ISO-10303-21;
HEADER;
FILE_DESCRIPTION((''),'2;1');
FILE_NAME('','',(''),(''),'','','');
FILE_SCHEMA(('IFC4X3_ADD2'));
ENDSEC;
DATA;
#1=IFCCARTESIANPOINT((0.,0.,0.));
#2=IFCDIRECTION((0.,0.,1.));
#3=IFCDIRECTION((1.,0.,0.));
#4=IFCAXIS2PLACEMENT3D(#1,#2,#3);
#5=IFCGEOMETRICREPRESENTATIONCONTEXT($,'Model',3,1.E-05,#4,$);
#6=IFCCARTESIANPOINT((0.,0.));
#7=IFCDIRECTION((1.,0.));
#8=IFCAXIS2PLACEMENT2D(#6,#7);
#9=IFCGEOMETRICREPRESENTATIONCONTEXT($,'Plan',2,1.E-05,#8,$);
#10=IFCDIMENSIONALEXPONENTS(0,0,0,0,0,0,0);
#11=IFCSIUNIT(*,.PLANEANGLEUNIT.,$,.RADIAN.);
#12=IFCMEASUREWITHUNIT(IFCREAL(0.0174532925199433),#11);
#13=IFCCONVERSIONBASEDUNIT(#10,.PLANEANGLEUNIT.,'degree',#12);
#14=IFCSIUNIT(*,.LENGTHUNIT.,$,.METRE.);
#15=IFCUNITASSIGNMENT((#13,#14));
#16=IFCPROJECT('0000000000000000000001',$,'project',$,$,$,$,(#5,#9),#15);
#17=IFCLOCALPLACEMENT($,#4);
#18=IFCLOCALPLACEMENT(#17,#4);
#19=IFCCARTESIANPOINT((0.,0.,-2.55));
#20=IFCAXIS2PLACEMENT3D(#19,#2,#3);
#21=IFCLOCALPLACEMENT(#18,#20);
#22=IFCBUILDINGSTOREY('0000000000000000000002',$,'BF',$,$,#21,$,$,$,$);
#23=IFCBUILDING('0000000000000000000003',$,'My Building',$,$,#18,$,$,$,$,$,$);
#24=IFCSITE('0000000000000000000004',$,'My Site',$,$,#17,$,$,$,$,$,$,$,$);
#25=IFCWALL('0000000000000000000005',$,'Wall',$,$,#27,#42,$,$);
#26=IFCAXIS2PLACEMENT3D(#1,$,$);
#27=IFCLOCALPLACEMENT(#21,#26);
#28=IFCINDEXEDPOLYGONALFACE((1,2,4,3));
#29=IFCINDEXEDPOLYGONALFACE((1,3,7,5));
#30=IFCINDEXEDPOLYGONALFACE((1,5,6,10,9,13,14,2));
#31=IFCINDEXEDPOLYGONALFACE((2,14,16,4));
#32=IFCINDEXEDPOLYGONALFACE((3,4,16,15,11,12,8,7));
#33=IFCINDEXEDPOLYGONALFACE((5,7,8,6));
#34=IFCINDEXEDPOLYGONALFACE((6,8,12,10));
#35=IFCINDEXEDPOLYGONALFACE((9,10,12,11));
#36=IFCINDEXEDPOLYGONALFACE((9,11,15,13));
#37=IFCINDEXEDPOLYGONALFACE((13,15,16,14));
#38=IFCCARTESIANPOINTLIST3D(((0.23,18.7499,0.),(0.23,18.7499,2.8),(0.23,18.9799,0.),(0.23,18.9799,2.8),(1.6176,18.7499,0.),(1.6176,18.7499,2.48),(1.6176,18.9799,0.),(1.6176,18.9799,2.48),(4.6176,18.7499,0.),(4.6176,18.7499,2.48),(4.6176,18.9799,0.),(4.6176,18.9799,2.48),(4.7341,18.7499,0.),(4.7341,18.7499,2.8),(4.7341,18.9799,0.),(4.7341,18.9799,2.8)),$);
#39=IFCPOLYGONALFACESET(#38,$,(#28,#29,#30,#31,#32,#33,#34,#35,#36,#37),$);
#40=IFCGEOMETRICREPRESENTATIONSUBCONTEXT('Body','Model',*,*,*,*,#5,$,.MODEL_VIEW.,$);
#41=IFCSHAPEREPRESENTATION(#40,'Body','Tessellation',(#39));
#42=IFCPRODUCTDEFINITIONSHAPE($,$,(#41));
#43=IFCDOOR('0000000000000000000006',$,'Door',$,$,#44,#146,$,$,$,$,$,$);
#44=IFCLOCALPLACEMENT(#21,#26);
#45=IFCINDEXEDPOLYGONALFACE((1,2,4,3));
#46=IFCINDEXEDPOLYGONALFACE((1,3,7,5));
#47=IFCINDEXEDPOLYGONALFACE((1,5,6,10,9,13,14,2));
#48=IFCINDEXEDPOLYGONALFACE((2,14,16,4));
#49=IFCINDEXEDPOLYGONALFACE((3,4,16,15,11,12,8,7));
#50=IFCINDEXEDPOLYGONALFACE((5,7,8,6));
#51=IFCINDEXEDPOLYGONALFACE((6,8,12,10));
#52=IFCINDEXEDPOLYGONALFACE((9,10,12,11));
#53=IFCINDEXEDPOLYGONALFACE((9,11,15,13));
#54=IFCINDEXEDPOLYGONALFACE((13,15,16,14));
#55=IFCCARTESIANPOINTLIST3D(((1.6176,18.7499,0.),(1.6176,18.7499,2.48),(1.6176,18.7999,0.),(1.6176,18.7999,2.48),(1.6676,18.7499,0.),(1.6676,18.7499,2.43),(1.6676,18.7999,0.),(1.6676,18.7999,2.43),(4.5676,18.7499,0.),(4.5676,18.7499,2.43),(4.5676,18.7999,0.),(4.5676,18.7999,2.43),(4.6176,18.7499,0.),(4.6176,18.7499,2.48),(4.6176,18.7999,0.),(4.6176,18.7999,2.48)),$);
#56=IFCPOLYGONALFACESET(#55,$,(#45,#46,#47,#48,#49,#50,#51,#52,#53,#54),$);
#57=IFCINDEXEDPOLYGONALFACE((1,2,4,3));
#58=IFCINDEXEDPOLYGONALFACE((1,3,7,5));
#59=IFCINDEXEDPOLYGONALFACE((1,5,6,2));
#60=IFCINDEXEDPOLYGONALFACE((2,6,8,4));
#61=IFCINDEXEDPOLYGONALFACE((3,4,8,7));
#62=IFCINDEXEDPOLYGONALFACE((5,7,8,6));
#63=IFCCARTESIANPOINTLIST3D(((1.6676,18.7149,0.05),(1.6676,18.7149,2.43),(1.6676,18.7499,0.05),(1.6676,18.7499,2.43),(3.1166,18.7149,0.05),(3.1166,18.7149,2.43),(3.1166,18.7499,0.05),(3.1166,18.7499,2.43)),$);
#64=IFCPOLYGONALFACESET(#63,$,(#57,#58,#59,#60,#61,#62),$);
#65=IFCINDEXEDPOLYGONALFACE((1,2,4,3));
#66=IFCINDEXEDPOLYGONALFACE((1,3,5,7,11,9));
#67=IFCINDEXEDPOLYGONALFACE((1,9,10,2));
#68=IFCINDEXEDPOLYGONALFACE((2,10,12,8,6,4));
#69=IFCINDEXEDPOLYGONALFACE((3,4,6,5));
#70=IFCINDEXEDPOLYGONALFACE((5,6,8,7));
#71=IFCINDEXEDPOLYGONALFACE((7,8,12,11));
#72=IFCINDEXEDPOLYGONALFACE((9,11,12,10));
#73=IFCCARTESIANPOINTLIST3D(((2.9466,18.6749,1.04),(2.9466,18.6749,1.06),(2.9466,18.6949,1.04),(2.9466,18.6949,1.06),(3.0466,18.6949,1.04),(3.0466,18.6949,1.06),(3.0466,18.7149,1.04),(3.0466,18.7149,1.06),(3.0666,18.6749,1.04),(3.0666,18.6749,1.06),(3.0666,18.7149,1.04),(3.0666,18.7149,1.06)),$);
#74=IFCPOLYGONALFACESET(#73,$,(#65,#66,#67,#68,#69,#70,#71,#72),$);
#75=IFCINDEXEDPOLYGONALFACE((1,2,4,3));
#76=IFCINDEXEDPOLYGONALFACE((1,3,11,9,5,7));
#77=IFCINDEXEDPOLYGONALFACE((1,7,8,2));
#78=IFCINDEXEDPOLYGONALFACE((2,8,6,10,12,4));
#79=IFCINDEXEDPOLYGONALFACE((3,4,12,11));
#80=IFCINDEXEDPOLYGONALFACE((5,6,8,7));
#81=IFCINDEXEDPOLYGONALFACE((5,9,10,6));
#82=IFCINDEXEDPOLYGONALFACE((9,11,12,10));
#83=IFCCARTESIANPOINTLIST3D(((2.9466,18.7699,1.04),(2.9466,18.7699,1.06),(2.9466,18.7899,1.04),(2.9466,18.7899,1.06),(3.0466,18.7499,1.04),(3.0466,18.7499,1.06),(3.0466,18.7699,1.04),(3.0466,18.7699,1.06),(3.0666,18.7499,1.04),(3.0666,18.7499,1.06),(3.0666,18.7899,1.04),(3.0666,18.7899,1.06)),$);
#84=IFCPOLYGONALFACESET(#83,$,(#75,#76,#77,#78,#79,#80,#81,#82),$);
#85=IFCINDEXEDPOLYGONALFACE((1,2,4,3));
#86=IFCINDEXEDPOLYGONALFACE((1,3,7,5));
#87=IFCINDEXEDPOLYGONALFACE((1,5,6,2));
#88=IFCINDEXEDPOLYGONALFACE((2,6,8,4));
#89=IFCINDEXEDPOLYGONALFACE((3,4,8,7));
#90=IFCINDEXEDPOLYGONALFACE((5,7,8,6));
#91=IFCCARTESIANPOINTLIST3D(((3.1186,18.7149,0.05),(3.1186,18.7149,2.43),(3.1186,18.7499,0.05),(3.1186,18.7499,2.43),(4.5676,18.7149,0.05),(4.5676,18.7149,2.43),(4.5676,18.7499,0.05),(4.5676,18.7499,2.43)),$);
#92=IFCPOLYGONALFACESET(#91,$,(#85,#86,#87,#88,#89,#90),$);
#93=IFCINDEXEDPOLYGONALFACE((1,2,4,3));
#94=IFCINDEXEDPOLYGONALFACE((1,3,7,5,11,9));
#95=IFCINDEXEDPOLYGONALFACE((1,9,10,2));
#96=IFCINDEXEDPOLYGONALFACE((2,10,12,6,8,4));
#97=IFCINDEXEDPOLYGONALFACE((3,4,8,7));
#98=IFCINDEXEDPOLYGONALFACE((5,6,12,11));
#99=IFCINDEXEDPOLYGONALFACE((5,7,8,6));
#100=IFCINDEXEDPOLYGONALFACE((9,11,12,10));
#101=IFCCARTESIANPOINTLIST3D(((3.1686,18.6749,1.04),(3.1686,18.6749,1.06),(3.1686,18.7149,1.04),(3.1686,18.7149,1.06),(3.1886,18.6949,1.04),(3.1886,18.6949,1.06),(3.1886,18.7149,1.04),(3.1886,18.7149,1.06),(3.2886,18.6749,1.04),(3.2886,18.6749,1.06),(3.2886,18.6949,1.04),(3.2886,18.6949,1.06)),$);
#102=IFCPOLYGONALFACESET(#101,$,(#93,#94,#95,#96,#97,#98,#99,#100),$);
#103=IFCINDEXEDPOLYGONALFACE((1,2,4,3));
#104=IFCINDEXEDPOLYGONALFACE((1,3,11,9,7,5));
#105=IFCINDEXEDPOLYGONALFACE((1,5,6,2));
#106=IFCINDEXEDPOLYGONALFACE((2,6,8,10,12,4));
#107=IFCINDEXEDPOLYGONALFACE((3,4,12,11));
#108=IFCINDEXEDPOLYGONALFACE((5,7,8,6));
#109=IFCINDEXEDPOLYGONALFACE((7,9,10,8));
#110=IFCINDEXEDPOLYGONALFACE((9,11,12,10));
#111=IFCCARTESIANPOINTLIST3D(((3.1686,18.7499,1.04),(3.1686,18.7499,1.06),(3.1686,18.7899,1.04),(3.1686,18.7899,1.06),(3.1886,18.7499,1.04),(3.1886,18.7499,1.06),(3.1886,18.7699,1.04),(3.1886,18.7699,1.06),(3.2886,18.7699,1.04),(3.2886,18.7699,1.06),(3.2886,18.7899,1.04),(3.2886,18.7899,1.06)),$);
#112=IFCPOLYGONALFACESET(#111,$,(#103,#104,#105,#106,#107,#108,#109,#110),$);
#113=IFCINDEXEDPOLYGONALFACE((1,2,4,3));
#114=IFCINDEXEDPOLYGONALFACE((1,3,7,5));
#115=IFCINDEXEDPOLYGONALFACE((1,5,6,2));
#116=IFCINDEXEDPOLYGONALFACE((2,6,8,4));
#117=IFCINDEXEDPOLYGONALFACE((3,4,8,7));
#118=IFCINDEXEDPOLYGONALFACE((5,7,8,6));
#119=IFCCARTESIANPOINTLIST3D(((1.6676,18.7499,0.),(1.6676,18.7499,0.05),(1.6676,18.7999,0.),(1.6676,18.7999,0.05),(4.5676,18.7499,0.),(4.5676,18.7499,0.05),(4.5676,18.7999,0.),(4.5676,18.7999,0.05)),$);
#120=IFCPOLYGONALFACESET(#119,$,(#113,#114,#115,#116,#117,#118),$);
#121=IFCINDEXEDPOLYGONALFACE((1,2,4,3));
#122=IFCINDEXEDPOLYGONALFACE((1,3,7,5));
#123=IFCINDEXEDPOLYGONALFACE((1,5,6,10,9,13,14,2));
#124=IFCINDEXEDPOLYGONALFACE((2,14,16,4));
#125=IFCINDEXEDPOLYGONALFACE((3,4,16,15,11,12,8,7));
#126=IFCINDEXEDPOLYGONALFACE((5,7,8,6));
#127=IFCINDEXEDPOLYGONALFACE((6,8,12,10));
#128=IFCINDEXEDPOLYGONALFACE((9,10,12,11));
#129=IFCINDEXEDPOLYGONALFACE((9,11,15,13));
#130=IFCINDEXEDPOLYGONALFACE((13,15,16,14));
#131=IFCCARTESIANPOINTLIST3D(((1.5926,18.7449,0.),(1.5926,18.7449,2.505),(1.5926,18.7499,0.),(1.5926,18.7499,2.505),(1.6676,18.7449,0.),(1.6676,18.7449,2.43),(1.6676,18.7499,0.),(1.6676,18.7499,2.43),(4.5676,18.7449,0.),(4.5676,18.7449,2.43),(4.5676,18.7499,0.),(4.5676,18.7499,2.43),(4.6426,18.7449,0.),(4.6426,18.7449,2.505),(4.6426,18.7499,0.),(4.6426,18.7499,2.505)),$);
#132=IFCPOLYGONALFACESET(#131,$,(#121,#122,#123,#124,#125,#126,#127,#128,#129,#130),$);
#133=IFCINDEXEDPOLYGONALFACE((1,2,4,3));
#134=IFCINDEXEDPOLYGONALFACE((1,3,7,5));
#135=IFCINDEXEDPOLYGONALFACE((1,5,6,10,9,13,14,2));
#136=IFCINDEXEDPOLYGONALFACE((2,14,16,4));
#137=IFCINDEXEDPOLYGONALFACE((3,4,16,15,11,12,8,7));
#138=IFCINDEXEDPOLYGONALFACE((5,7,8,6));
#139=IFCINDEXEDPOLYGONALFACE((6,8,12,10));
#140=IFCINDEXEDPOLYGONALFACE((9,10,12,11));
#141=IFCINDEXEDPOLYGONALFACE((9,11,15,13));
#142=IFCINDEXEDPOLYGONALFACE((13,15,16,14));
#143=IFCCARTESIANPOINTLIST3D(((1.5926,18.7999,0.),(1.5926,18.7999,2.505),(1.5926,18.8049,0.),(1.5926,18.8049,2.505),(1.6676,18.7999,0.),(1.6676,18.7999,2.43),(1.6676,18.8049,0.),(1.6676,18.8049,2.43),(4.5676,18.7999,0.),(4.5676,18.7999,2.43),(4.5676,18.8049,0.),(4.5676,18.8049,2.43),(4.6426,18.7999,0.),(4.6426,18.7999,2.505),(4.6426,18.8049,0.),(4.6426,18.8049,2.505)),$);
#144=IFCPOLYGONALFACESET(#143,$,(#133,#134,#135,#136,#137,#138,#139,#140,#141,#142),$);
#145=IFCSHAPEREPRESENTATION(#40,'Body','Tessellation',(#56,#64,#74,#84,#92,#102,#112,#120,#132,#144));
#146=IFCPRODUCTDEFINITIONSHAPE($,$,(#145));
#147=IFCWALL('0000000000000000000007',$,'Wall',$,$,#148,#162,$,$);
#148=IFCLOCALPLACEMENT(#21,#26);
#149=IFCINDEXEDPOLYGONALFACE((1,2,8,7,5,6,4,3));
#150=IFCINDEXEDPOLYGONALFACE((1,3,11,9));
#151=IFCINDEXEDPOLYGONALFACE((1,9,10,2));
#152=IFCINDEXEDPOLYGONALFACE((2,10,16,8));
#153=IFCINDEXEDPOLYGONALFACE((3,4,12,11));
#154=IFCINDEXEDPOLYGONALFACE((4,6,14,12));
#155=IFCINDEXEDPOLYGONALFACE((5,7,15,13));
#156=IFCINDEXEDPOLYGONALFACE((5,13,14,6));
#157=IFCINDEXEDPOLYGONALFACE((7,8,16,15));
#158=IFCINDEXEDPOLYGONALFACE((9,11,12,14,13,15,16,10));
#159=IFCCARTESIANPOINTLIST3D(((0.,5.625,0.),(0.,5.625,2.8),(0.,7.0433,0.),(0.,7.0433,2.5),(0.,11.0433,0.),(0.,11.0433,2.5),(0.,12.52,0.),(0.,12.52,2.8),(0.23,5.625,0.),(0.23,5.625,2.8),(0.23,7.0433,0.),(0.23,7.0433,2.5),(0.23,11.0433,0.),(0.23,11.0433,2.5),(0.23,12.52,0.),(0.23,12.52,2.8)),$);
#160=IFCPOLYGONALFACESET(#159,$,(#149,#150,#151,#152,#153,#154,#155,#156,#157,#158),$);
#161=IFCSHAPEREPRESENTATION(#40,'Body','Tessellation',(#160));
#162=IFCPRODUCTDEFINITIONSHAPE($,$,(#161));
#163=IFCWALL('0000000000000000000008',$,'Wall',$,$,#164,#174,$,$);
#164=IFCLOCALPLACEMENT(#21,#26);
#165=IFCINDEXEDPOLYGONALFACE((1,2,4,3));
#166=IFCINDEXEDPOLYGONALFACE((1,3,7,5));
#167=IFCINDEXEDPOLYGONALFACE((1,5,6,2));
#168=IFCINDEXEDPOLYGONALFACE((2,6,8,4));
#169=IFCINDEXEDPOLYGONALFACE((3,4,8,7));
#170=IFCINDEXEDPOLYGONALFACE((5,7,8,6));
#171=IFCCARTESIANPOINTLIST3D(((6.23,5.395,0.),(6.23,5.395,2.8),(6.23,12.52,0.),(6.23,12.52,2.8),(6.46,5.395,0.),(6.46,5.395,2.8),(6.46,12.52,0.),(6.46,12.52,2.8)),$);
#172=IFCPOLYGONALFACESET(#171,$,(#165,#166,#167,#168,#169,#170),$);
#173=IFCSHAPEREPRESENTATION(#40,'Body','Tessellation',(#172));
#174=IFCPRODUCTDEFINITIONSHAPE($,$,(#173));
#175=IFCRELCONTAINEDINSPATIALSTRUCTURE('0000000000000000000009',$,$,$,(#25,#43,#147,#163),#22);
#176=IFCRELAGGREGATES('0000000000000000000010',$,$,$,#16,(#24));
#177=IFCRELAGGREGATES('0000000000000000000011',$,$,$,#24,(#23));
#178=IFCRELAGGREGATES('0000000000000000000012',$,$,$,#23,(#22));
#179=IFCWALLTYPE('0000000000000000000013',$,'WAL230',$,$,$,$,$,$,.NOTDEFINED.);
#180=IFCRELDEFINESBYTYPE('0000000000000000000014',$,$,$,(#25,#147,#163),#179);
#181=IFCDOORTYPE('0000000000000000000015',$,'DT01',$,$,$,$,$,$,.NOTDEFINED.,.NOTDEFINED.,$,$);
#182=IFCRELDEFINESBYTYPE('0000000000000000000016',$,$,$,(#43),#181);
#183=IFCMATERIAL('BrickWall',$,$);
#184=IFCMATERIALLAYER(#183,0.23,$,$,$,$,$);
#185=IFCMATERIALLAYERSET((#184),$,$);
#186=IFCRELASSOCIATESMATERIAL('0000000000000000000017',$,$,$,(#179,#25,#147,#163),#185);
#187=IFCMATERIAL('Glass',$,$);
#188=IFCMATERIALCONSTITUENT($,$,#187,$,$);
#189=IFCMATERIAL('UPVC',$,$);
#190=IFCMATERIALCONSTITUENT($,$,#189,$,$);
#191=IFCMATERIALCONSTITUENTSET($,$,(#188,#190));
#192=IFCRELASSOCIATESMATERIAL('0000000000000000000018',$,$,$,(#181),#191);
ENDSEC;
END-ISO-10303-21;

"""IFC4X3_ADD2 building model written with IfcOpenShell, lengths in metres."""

from ifc_helpers import new_model, entity, si_unit, converted_unit, frame, origin_with_axes, origin_2d_with_axis, place, context, subcontext, project, spatial, line, indexed_curve, outline, extrude, shape, source, transform, mapped, material, layer, layer_set, layer_usage, constituent, constituent_set, type_object, type_shapes, element, fill, save


model = new_model("IFC4X3_ADD2")

# Units and contexts
model_context = context("Model", 3, precision=1e-05, world=origin_with_axes())
plan_context = context("Plan", 2, precision=1e-05, world=origin_2d_with_axis())
body_context_1 = subcontext(model_context, "Body", "Model", "MODEL_VIEW")
body_context_2 = subcontext(plan_context, "Body", "Plan", "PLAN_VIEW")
ifc_project = project(units=[converted_unit("PLANEANGLEUNIT", "degree", entity("IfcReal", 0.0174532925199433), si_unit("PLANEANGLEUNIT", "RADIAN"), dimensions=[0, 0, 0, 0, 0, 0, 0]), si_unit("LENGTHUNIT", "METRE")], contexts=[model_context, plan_context])

# Site, building, storey
site_placement = place(None, origin_with_axes())
site = spatial("IfcSite", under=ifc_project, at=site_placement, Name="My Site")
building_placement = place(site_placement, origin_with_axes())
building = spatial("IfcBuilding", under=site, at=building_placement, Name="My Building")
storey_placement = place(building_placement, frame((0.0, 0.0, -2.55), z_axis=(0.0, 0.0, 1.0), x_axis=(1.0, 0.0, 0.0)))
storey = spatial("IfcBuildingStorey", under=building, at=storey_placement, Name="BF")

# Shared definitions
ifc_material_1 = material(Name="BrickWall")

# Wall, opening, door
ifc_layer_1 = layer(ifc_material_1, 0.23)
ifc_layer_set_1 = layer_set([ifc_layer_1])
ifc_layer_usage_1 = layer_usage(ifc_layer_set_1, "AXIS2", "POSITIVE", 0.0)
wall_type = type_object("IfcWallType", Name="WAL230", PredefinedType="NOTDEFINED", material=ifc_layer_set_1)
wall_1_placement = place(storey_placement, frame((0.23, 18.7499, 0.0), z_axis=(0.0, 0.0, 1.0), x_axis=(1.0, 0.0, 0.0)))
wall_1 = element("IfcWall", 1, at=wall_1_placement, inside=storey, type_object=wall_type, material=ifc_layer_usage_1, Name="Wall", context=body_context_1, shape_type="SweptSolid", body=[
    extrude(outline(indexed_curve([(0.0, 0.0), (0.0, 0.23), (4.5041, 0.23), (4.5041, 0.0), (0.0, 0.0)], self_intersect=False)), origin_with_axes(), (0.0, 0.0, 1.0), 2.8),
])
shared_shape_1 = source(origin_with_axes(), body_context_1, "Body", "SweptSolid", [
    extrude(outline(indexed_curve([(0.0, 0.0), (3.0, 0.0), (3.0, 2.48), (0.0, 2.48)], segments=[line(1, 2, 3, 4, 1)])), frame((0.0, -0.6, 0.0), z_axis=(0.0, -1.0, 0.0), x_axis=(1.0, 0.0, 0.0)), (0.0, 0.0, -1.0), 1.2),
])
opening_1_placement = place(wall_1_placement, frame((1.3876, 0.0, 0.0), z_axis=(0.0, 0.0, 1.0), x_axis=(1.0, 0.0, 0.0)))
opening_1 = element("IfcOpeningElement", 2, at=opening_1_placement, cuts=wall_1, PredefinedType="OPENING", context=body_context_1, shape_type="MappedRepresentation", body=[
    mapped(shared_shape_1, transform((0.0, 0.0, 0.0), x_axis=(1.0, 0.0, 0.0), y_axis=(0.0, 1.0, 0.0), z_axis=(0.0, 0.0, 1.0), scale=1.0)),
])
ifc_material_2 = material(Name="Glass")
ifc_constituent_1 = constituent(ifc_material_2)
ifc_material_3 = material(Name="UPVC")
ifc_constituent_2 = constituent(ifc_material_3)
ifc_constituent_set = constituent_set(constituents=[ifc_constituent_1, ifc_constituent_2])
door_type = type_object("IfcDoorType", Name="DT01", OperationType="NOTDEFINED", PredefinedType="NOTDEFINED", material=ifc_constituent_set)
shared_shape_2 = source(origin_with_axes(), body_context_1, "Body", "SweptSolid", [
    extrude(outline(indexed_curve([(3.0, 0.0), (3.0, 2.48), (0.0, 2.48), (0.0, 0.0), (0.05, 0.0), (0.05, 2.43), (2.95, 2.43), (2.95, 0.0)], segments=[line(5, 4), line(4, 3), line(3, 2), line(2, 1), line(1, 8), line(8, 7), line(7, 6), line(6, 5)], self_intersect=False)), frame((0.0, 0.0, 0.0), z_axis=(0.0, -1.0, 0.0), x_axis=(1.0, 0.0, 0.0)), (0.0, 0.0, -1.0), 0.05),
    extrude(outline(indexed_curve([(0.0, 0.0), (1.449, 0.0), (1.449, 0.035), (0.0, 0.035)], segments=[line(1, 2, 3, 4, 1)])), frame((0.05, -0.035, 0.05), z_axis=(0.0, 0.0, 1.0), x_axis=(1.0, 0.0, 0.0)), (0.0, 0.0, 1.0), 2.38),
    extrude(outline(indexed_curve([(0.0, 0.0), (0.0, -0.04), (-0.12, -0.04), (-0.12, -0.02), (-0.02, -0.02), (-0.02, 0.0)], segments=[line(1, 2, 3, 4, 5, 6, 1)])), frame((1.449, -0.035, 1.04), z_axis=(0.0, 0.0, 1.0), x_axis=(1.0, 0.0, 0.0)), (0.0, 0.0, 1.0), 0.02),
    extrude(outline(indexed_curve([(0.0, 0.0), (0.0, 0.04), (-0.12, 0.04), (-0.12, 0.02), (-0.02, 0.02), (-0.02, 0.0)], segments=[line(1, 2, 3, 4, 5, 6, 1)])), frame((1.449, 0.0, 1.04), z_axis=(0.0, 0.0, 1.0), x_axis=(1.0, 0.0, 0.0)), (0.0, 0.0, 1.0), 0.02),
    extrude(outline(indexed_curve([(0.0, 0.0), (-1.449, 0.0), (-1.449, 0.035), (0.0, 0.035)], segments=[line(1, 2, 3, 4, 1)])), frame((2.95, -0.035, 0.05), z_axis=(0.0, 0.0, 1.0), x_axis=(1.0, 0.0, 0.0)), (0.0, 0.0, 1.0), 2.38),
    extrude(outline(indexed_curve([(0.0, 0.0), (0.0, -0.04), (0.12, -0.04), (0.12, -0.02), (0.02, -0.02), (0.02, 0.0)], segments=[line(1, 2, 3, 4, 5, 6, 1)])), frame((1.551, -0.035, 1.04), z_axis=(0.0, 0.0, 1.0), x_axis=(1.0, 0.0, 0.0)), (0.0, 0.0, 1.0), 0.02),
    extrude(outline(indexed_curve([(0.0, 0.0), (0.0, 0.04), (0.12, 0.04), (0.12, 0.02), (0.02, 0.02), (0.02, 0.0)], segments=[line(1, 2, 3, 4, 5, 6, 1)])), frame((1.551, 0.0, 1.04), z_axis=(0.0, 0.0, 1.0), x_axis=(1.0, 0.0, 0.0)), (0.0, 0.0, 1.0), 0.02),
    extrude(outline(indexed_curve([(0.0, 0.0), (2.9, 0.0), (2.9, 0.05), (0.0, 0.05)], segments=[line(1, 2, 3, 4, 1)])), frame((0.05, 0.0, 0.0), z_axis=(0.0, 0.0, 1.0), x_axis=(1.0, 0.0, 0.0)), (0.0, 0.0, 1.0), 0.05),
    extrude(outline(indexed_curve([(0.0, 0.0), (0.0, 2.505), (3.05, 2.505), (3.05, 0.0), (2.975, 0.0), (2.975, 2.43), (0.075, 2.43), (0.075, 0.0)], segments=[line(1, 2, 3, 4, 5, 6, 7, 8, 1)])), frame((-0.025, -0.005, 0.0), z_axis=(0.0, -1.0, 0.0), x_axis=(1.0, 0.0, 0.0)), (0.0, 0.0, -1.0), 0.005),
    extrude(outline(indexed_curve([(0.0, 0.0), (0.0, 2.505), (3.05, 2.505), (3.05, 0.0), (2.975, 0.0), (2.975, 2.43), (0.075, 2.43), (0.075, 0.0)], segments=[line(1, 2, 3, 4, 5, 6, 7, 8, 1)])), frame((-0.025, 0.05, 0.0), z_axis=(0.0, -1.0, 0.0), x_axis=(1.0, 0.0, 0.0)), (0.0, 0.0, -1.0), 0.005),
])
shared_shape_3 = source(origin_with_axes(), body_context_2, "Body", "Curve2D", [
    entity("IfcIndexedPolyCurve", entity("IfcCartesianPointList2D", [[0.0, 0.0], [0.05, 0.0], [0.05, 0.05], [0.0, 0.05]]), [entity("IfcLineIndex", [1, 2, 3, 4, 1])]),
    entity("IfcIndexedPolyCurve", entity("IfcCartesianPointList2D", [[3.0, 0.0], [2.95, 0.0], [2.95, 0.05], [3.0, 0.05]]), [entity("IfcLineIndex", [1, 2, 3, 4, 1])]),
    entity("IfcIndexedPolyCurve", entity("IfcCartesianPointList2D", [[-0.675, -0.035], [0.775, -0.035], [0.775, 0.0], [-0.675, 0.0]]), [entity("IfcLineIndex", [1, 2, 3, 4, 1])]),
    entity("IfcIndexedPolyCurve", entity("IfcCartesianPointList2D", [[3.675, -0.035], [2.225, -0.035], [2.225, 0.0], [3.675, 0.0]]), [entity("IfcLineIndex", [1, 2, 3, 4, 1])]),
])
type_shapes(door_type, [shared_shape_2, shared_shape_3])
door_1_placement = place(opening_1_placement, origin_with_axes())
door_1 = element("IfcDoor", 3, at=door_1_placement, inside=storey, type_object=door_type, Name="Door", shapes=[
    shape(body_context_1, "Body", "MappedRepresentation", [mapped(shared_shape_2, transform((0.0, 0.0, 0.0), x_axis=(1.0, 0.0, 0.0), y_axis=(0.0, 1.0, 0.0), z_axis=(0.0, 0.0, 1.0), scale=1.0))]),
    shape(body_context_2, "Body", "MappedRepresentation", [mapped(shared_shape_3, transform((0.0, 0.0, 0.0), x_axis=(1.0, 0.0, 0.0), y_axis=(0.0, 1.0, 0.0), z_axis=(0.0, 0.0, 1.0), scale=1.0))]),
])
fill(opening_1, door_1)

# Wall, opening
ifc_layer_usage_2 = layer_usage(ifc_layer_set_1, "AXIS2", "POSITIVE", 0.0)
wall_2_placement = place(storey_placement, frame((0.23, 5.625, 0.0), z_axis=(0.0, 0.0, 1.0), x_axis=(0.0, 1.0, 0.0)))
wall_2 = element("IfcWall", 4, at=wall_2_placement, inside=storey, type_object=wall_type, material=ifc_layer_usage_2, Name="Wall", context=body_context_1, shape_type="SweptSolid", body=[
    extrude(outline(indexed_curve([(0.0, 0.0), (0.0, 0.23), (6.895, 0.23), (6.895, 0.0), (0.0, 0.0)], self_intersect=False)), origin_with_axes(), (0.0, 0.0, 1.0), 2.8),
])
shared_shape_4 = source(origin_with_axes(), body_context_1, "Body", "SweptSolid", [
    extrude(outline(indexed_curve([(0.0, 0.0), (4.0, 0.0), (4.0, 2.5), (0.0, 2.5)], segments=[line(1, 2, 3, 4, 1)])), frame((0.0, -0.6, 0.0), z_axis=(0.0, -1.0, 0.0), x_axis=(1.0, 0.0, 0.0)), (0.0, 0.0, -1.0), 1.2),
])
opening_2_placement = place(wall_2_placement, frame((1.4183, 0.0, 0.0), z_axis=(0.0, 0.0, 1.0), x_axis=(1.0, 0.0, 0.0)))
element("IfcOpeningElement", 5, at=opening_2_placement, cuts=wall_2, PredefinedType="OPENING", context=body_context_1, shape_type="MappedRepresentation", body=[
    mapped(shared_shape_4, transform((0.0, 0.0, 0.0), x_axis=(1.0, 0.0, 0.0), y_axis=(0.0, 1.0, 0.0), z_axis=(0.0, 0.0, 1.0), scale=1.0)),
])

# Wall
ifc_layer_usage_3 = layer_usage(ifc_layer_set_1, "AXIS2", "POSITIVE", 0.0)
wall_3_placement = place(storey_placement, frame((6.46, 5.395, 0.0), z_axis=(0.0, 0.0, 1.0), x_axis=(0.0, 1.0, 0.0)))
element("IfcWall", 6, at=wall_3_placement, inside=storey, type_object=wall_type, material=ifc_layer_usage_3, Name="Wall", context=body_context_1, shape_type="SweptSolid", body=[
    extrude(outline(indexed_curve([(0.0, 0.0), (0.0, 0.23), (7.125, 0.23), (7.125, 0.0), (0.0, 0.0)], self_intersect=False)), origin_with_axes(), (0.0, 0.0, 1.0), 2.8),
])

save(model, "model.ifc")
